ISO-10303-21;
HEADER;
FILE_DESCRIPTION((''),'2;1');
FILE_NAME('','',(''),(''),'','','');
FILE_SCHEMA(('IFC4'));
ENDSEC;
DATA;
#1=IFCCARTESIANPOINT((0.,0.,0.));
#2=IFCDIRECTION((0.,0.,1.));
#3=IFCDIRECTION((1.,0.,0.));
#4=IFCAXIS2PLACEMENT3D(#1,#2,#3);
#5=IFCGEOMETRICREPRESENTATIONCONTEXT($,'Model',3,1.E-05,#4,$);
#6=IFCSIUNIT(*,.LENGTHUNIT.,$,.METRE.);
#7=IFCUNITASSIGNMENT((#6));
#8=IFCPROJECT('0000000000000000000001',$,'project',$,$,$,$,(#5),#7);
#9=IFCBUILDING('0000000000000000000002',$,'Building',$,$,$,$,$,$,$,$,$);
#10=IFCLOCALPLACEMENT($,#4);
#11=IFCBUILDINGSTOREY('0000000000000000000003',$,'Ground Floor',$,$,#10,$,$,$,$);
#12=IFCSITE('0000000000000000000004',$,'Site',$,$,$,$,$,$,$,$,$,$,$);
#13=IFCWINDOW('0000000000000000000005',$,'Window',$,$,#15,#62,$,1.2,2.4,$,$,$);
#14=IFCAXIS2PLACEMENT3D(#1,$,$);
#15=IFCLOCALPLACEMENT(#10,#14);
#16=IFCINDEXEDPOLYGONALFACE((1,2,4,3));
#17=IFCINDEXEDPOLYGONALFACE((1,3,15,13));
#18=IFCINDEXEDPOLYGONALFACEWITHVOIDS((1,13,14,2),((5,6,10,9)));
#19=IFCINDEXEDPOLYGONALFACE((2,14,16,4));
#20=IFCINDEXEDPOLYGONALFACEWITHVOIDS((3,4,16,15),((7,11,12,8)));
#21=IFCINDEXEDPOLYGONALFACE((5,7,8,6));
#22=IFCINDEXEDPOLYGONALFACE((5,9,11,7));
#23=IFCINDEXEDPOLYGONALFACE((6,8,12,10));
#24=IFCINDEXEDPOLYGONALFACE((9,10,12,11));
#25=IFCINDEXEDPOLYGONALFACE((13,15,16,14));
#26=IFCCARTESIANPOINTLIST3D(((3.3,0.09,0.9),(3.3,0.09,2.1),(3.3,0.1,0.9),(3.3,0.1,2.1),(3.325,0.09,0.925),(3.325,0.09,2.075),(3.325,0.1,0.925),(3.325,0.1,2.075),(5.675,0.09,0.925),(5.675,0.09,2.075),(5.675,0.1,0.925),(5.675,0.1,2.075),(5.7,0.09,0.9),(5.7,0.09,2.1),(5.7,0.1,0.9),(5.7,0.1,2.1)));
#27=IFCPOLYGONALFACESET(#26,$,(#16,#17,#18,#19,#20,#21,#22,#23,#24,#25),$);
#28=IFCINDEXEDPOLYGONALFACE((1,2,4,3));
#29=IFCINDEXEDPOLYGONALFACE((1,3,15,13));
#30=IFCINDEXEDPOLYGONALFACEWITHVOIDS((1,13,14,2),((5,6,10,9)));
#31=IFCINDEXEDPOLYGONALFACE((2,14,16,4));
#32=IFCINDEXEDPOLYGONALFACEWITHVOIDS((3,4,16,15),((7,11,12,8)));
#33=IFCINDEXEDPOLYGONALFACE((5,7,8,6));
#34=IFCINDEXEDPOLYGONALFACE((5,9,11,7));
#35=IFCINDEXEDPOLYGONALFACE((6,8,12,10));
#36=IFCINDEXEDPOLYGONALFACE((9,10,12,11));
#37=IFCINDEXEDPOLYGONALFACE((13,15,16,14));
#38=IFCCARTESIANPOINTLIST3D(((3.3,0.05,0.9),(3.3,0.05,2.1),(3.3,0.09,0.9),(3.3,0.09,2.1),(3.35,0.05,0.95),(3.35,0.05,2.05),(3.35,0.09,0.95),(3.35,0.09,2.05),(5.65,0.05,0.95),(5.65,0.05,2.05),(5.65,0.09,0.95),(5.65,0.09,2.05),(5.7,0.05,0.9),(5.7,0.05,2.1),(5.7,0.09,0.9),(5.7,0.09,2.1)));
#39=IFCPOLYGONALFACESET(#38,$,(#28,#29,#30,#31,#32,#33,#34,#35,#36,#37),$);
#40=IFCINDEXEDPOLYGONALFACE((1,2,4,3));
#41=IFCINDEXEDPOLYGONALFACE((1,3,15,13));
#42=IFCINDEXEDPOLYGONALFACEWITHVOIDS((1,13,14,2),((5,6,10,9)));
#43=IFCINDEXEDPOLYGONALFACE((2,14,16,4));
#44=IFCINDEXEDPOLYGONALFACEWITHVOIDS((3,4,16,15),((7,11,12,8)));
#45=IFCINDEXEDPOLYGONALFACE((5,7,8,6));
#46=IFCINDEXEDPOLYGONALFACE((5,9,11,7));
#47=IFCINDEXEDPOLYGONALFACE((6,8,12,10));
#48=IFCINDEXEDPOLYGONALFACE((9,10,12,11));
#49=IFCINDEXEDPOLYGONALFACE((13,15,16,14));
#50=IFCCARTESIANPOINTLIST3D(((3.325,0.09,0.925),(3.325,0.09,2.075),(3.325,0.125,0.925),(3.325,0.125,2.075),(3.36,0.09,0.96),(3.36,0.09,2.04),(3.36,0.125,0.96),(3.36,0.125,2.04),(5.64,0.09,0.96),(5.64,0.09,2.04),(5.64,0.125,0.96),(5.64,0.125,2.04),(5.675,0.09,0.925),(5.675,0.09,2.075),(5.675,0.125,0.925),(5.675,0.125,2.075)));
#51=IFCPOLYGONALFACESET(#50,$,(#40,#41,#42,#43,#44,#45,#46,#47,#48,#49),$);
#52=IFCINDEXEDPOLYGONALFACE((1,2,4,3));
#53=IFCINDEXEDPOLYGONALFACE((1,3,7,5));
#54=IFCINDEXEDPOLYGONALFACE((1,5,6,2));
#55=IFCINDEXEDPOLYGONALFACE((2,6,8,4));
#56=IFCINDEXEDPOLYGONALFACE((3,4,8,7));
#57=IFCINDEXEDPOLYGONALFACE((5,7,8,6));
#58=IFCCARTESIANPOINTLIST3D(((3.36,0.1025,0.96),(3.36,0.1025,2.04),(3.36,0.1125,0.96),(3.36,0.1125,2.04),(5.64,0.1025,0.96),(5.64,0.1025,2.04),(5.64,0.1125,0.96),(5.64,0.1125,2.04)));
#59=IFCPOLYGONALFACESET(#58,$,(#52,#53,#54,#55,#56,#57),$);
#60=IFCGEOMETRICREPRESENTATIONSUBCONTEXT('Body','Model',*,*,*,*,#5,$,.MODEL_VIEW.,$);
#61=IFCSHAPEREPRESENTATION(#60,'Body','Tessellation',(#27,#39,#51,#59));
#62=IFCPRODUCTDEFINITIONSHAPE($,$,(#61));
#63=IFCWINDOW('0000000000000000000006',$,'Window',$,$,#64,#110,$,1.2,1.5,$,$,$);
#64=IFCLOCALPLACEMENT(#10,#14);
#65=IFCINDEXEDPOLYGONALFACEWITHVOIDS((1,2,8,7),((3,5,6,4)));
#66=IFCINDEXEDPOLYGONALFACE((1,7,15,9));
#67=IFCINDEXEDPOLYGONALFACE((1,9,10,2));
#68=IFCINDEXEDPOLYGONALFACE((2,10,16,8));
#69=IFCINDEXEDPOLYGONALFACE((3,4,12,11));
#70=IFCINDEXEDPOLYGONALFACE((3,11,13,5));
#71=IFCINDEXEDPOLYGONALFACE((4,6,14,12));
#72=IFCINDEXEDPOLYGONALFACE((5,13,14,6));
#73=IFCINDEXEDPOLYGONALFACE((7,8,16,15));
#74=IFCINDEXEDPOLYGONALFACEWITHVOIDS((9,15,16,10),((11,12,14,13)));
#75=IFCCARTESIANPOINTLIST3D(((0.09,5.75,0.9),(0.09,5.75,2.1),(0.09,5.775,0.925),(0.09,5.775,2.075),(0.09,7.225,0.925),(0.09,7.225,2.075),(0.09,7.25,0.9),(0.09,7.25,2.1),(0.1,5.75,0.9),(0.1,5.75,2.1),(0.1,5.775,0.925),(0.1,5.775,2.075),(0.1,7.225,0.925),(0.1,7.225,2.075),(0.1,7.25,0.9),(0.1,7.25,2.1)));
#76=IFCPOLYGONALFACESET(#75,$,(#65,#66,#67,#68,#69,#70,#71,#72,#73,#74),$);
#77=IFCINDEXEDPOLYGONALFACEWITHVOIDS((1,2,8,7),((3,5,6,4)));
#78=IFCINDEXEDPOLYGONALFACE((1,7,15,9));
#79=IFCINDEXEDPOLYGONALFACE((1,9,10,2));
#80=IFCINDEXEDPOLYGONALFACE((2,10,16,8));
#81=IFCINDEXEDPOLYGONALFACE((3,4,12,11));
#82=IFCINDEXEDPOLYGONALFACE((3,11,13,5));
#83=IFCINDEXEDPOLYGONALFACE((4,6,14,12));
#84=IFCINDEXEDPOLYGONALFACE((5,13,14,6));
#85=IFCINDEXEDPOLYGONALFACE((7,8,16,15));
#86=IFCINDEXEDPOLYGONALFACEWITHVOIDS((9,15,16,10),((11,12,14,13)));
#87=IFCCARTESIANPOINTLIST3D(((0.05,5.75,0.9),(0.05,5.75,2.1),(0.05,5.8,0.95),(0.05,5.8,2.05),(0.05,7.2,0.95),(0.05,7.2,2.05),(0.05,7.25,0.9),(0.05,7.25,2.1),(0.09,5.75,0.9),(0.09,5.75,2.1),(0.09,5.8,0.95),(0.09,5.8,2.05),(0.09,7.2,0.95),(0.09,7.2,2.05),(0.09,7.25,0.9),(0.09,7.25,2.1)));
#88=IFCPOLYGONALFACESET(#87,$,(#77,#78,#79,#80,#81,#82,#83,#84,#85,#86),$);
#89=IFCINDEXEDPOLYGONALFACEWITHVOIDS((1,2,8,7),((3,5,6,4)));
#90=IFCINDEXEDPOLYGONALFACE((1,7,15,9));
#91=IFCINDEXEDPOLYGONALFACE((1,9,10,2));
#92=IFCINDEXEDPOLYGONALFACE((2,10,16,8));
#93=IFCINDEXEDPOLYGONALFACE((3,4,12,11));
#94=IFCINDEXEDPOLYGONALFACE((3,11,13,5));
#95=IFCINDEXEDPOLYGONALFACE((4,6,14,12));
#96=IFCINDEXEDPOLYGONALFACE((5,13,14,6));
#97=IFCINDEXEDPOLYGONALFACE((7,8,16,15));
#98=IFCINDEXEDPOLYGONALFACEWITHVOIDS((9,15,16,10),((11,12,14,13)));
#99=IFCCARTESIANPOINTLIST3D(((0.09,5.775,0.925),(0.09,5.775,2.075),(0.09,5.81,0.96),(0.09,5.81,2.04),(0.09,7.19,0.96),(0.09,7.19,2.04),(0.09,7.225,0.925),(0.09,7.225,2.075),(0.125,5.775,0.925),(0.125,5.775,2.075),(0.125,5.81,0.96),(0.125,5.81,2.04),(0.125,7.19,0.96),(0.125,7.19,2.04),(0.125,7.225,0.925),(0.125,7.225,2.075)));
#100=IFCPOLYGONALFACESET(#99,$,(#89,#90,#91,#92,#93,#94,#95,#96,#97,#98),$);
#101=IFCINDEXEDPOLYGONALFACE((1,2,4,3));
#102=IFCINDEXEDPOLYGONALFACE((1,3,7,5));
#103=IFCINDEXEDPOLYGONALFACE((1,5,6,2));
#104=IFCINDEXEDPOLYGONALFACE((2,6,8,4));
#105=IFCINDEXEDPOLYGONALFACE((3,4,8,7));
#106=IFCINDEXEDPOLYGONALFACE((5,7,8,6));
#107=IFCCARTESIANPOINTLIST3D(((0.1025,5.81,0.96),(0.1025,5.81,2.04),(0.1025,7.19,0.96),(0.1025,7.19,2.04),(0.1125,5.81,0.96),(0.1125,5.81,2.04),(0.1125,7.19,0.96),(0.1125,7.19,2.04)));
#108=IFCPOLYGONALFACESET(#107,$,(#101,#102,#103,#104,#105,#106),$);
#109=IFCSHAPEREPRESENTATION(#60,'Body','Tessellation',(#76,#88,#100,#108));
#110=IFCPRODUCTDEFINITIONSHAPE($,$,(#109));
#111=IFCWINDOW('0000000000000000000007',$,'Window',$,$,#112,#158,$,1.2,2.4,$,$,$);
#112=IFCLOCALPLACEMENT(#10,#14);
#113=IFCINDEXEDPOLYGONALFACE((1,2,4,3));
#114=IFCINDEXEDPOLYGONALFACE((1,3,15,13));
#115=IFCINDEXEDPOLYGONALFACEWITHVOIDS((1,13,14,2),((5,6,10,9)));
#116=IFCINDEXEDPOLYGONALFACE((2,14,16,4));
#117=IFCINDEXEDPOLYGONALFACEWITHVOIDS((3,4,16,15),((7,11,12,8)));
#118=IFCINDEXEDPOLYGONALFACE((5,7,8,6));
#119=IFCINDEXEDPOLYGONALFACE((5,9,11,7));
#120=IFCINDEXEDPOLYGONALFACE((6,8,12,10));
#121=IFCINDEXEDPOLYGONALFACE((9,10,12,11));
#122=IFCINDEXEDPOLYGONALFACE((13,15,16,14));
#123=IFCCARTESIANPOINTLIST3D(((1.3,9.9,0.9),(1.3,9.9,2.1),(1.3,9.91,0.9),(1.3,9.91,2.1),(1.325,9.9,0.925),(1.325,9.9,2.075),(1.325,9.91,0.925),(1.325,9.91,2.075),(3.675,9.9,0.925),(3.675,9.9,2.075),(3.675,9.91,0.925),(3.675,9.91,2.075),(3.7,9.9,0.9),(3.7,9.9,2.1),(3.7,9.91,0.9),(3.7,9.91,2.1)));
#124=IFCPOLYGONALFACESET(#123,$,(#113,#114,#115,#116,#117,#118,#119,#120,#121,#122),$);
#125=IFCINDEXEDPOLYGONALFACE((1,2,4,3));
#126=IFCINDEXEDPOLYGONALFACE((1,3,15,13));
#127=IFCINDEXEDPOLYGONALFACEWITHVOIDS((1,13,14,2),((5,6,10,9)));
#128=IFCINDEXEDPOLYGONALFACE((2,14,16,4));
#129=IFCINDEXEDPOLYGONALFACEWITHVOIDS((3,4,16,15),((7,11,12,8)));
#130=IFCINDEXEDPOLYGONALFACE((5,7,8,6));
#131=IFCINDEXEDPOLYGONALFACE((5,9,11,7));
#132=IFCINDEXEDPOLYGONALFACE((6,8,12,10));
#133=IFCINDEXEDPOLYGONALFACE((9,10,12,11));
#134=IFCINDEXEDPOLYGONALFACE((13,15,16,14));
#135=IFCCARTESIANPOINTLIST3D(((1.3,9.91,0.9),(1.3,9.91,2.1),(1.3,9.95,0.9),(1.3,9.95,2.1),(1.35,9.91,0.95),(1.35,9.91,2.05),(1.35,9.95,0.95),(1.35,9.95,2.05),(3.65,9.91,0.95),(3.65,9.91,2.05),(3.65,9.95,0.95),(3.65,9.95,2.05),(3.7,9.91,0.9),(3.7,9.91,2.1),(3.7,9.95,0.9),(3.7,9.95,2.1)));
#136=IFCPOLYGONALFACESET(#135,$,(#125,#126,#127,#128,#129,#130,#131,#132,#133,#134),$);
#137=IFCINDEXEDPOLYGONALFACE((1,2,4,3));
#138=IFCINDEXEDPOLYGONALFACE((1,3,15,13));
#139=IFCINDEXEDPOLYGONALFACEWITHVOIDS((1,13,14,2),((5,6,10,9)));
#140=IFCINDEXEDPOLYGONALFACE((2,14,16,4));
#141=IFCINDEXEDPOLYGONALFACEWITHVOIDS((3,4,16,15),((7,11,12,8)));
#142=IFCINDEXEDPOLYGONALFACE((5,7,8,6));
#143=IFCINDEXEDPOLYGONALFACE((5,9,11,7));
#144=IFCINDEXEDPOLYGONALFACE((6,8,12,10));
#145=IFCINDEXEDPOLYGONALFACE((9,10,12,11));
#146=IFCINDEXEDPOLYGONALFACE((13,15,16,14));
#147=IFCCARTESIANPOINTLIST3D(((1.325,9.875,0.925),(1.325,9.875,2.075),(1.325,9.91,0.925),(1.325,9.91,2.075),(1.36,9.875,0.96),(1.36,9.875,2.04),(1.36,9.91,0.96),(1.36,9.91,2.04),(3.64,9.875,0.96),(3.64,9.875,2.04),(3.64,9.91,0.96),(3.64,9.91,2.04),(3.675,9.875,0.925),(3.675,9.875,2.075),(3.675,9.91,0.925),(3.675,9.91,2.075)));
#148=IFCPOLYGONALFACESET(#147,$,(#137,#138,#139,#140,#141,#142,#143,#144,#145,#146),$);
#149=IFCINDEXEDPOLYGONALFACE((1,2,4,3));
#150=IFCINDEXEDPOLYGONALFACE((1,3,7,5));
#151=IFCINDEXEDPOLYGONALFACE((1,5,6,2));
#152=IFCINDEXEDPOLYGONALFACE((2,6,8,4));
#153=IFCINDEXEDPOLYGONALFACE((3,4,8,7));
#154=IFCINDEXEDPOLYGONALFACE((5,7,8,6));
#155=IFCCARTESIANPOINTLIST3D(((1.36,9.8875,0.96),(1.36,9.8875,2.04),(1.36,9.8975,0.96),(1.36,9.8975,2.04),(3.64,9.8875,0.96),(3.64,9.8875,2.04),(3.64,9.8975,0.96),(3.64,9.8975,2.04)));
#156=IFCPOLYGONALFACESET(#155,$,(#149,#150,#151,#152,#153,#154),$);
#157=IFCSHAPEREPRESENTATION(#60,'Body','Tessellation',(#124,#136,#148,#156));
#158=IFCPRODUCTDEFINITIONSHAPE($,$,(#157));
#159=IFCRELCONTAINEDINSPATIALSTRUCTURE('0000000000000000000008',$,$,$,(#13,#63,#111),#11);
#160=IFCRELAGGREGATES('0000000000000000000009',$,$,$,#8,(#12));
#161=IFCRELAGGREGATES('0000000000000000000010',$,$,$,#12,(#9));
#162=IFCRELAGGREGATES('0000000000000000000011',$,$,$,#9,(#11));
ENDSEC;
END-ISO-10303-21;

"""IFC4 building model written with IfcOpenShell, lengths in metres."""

from ifc_helpers import new_model, si_unit, frame, origin_with_axes, place, context, subcontext, project, spatial, line, indexed_curve, outline, extrude, element, save


model = new_model("IFC4")

# Units and contexts
model_context = context("Model", 3, precision=1e-05, world=origin_with_axes())
body_context = subcontext(model_context, "Body", "Model", "MODEL_VIEW")
ifc_project = project(units=[si_unit("LENGTHUNIT", "METRE")], contexts=[model_context])

# Site, building, storey
site = spatial("IfcSite", under=ifc_project, Name="Site")
building = spatial("IfcBuilding", under=site, Name="Building")
storey_placement = place(None, origin_with_axes())
storey = spatial("IfcBuildingStorey", under=building, at=storey_placement, Name="Ground Floor")

# Windows
window_1_placement = place(storey_placement, frame((3.3, 0.0, 0.9), z_axis=(0.0, 0.0, 1.0), x_axis=(1.0, 0.0, 0.0)))
element("IfcWindow", 1, at=window_1_placement, inside=storey, Name="Window", OverallHeight=1.2, OverallWidth=2.4, context=body_context, shape_type="SweptSolid", body=[
    extrude(outline(indexed_curve([(0.0, 0.0), (2.4, 0.0), (2.4, 1.2), (0.0, 1.2)], segments=[line(1, 2, 3, 4, 1)]), holes=[indexed_curve([(0.025, 0.025), (2.375, 0.025), (2.375, 1.175), (0.025, 1.175)], segments=[line(1, 2, 3, 4, 1)])]), frame((0.0, 0.09, 0.0), z_axis=(0.0, -1.0, 0.0), x_axis=(1.0, 0.0, 0.0)), (0.0, 0.0, -1.0), 0.01),
    extrude(outline(indexed_curve([(0.0, 0.0), (2.4, 0.0), (2.4, 1.2), (0.0, 1.2)], segments=[line(1, 2, 3, 4, 1)]), holes=[indexed_curve([(0.05, 0.05), (2.35, 0.05), (2.35, 1.15), (0.05, 1.15)], segments=[line(1, 2, 3, 4, 1)])]), frame((0.0, 0.05, 0.0), z_axis=(0.0, -1.0, 0.0), x_axis=(1.0, 0.0, 0.0)), (0.0, 0.0, -1.0), 0.04),
    extrude(outline(indexed_curve([(0.0, 0.0), (2.35, 0.0), (2.35, 1.15), (0.0, 1.15)], segments=[line(1, 2, 3, 4, 1)]), holes=[indexed_curve([(0.035, 0.035), (2.315, 0.035), (2.315, 1.115), (0.035, 1.115)], segments=[line(1, 2, 3, 4, 1)])]), frame((0.025, 0.09, 0.025), z_axis=(0.0, -1.0, 0.0), x_axis=(1.0, 0.0, 0.0)), (0.0, 0.0, -1.0), 0.035),
    extrude(outline(indexed_curve([(0.035, 0.035), (2.315, 0.035), (2.315, 1.115), (0.035, 1.115)], segments=[line(1, 2, 3, 4, 1)])), frame((0.025, 0.1025, 0.025), z_axis=(0.0, -1.0, 0.0), x_axis=(1.0, 0.0, 0.0)), (0.0, 0.0, -1.0), 0.01),
])
window_2_placement = place(storey_placement, frame((0.0, 7.25, 0.9), z_axis=(0.0, 0.0, 1.0), x_axis=(0.0, -1.0, 0.0)))
element("IfcWindow", 2, at=window_2_placement, inside=storey, Name="Window", OverallHeight=1.2, OverallWidth=1.5, context=body_context, shape_type="SweptSolid", body=[
    extrude(outline(indexed_curve([(0.0, 0.0), (1.5, 0.0), (1.5, 1.2), (0.0, 1.2)], segments=[line(1, 2, 3, 4, 1)]), holes=[indexed_curve([(0.025, 0.025), (1.475, 0.025), (1.475, 1.175), (0.025, 1.175)], segments=[line(1, 2, 3, 4, 1)])]), frame((0.0, 0.09, 0.0), z_axis=(0.0, -1.0, 0.0), x_axis=(1.0, 0.0, 0.0)), (0.0, 0.0, -1.0), 0.01),
    extrude(outline(indexed_curve([(0.0, 0.0), (1.5, 0.0), (1.5, 1.2), (0.0, 1.2)], segments=[line(1, 2, 3, 4, 1)]), holes=[indexed_curve([(0.05, 0.05), (1.45, 0.05), (1.45, 1.15), (0.05, 1.15)], segments=[line(1, 2, 3, 4, 1)])]), frame((0.0, 0.05, 0.0), z_axis=(0.0, -1.0, 0.0), x_axis=(1.0, 0.0, 0.0)), (0.0, 0.0, -1.0), 0.04),
    extrude(outline(indexed_curve([(0.0, 0.0), (1.45, 0.0), (1.45, 1.15), (0.0, 1.15)], segments=[line(1, 2, 3, 4, 1)]), holes=[indexed_curve([(0.035, 0.035), (1.415, 0.035), (1.415, 1.115), (0.035, 1.115)], segments=[line(1, 2, 3, 4, 1)])]), frame((0.025, 0.09, 0.025), z_axis=(0.0, -1.0, 0.0), x_axis=(1.0, 0.0, 0.0)), (0.0, 0.0, -1.0), 0.035),
    extrude(outline(indexed_curve([(0.035, 0.035), (1.415, 0.035), (1.415, 1.115), (0.035, 1.115)], segments=[line(1, 2, 3, 4, 1)])), frame((0.025, 0.1025, 0.025), z_axis=(0.0, -1.0, 0.0), x_axis=(1.0, 0.0, 0.0)), (0.0, 0.0, -1.0), 0.01),
])
window_3_placement = place(storey_placement, frame((3.7, 10.0, 0.9), z_axis=(0.0, 0.0, 1.0), x_axis=(-1.0, 0.0, 0.0)))
element("IfcWindow", 3, at=window_3_placement, inside=storey, Name="Window", OverallHeight=1.2, OverallWidth=2.4, context=body_context, shape_type="SweptSolid", body=[
    extrude(outline(indexed_curve([(0.0, 0.0), (2.4, 0.0), (2.4, 1.2), (0.0, 1.2)], segments=[line(1, 2, 3, 4, 1)]), holes=[indexed_curve([(0.025, 0.025), (2.375, 0.025), (2.375, 1.175), (0.025, 1.175)], segments=[line(1, 2, 3, 4, 1)])]), frame((0.0, 0.09, 0.0), z_axis=(0.0, -1.0, 0.0), x_axis=(1.0, 0.0, 0.0)), (0.0, 0.0, -1.0), 0.01),
    extrude(outline(indexed_curve([(0.0, 0.0), (2.4, 0.0), (2.4, 1.2), (0.0, 1.2)], segments=[line(1, 2, 3, 4, 1)]), holes=[indexed_curve([(0.05, 0.05), (2.35, 0.05), (2.35, 1.15), (0.05, 1.15)], segments=[line(1, 2, 3, 4, 1)])]), frame((0.0, 0.05, 0.0), z_axis=(0.0, -1.0, 0.0), x_axis=(1.0, 0.0, 0.0)), (0.0, 0.0, -1.0), 0.04),
    extrude(outline(indexed_curve([(0.0, 0.0), (2.35, 0.0), (2.35, 1.15), (0.0, 1.15)], segments=[line(1, 2, 3, 4, 1)]), holes=[indexed_curve([(0.035, 0.035), (2.315, 0.035), (2.315, 1.115), (0.035, 1.115)], segments=[line(1, 2, 3, 4, 1)])]), frame((0.025, 0.09, 0.025), z_axis=(0.0, -1.0, 0.0), x_axis=(1.0, 0.0, 0.0)), (0.0, 0.0, -1.0), 0.035),
    extrude(outline(indexed_curve([(0.035, 0.035), (2.315, 0.035), (2.315, 1.115), (0.035, 1.115)], segments=[line(1, 2, 3, 4, 1)])), frame((0.025, 0.1025, 0.025), z_axis=(0.0, -1.0, 0.0), x_axis=(1.0, 0.0, 0.0)), (0.0, 0.0, -1.0), 0.01),
])

save(model, "model.ifc")
